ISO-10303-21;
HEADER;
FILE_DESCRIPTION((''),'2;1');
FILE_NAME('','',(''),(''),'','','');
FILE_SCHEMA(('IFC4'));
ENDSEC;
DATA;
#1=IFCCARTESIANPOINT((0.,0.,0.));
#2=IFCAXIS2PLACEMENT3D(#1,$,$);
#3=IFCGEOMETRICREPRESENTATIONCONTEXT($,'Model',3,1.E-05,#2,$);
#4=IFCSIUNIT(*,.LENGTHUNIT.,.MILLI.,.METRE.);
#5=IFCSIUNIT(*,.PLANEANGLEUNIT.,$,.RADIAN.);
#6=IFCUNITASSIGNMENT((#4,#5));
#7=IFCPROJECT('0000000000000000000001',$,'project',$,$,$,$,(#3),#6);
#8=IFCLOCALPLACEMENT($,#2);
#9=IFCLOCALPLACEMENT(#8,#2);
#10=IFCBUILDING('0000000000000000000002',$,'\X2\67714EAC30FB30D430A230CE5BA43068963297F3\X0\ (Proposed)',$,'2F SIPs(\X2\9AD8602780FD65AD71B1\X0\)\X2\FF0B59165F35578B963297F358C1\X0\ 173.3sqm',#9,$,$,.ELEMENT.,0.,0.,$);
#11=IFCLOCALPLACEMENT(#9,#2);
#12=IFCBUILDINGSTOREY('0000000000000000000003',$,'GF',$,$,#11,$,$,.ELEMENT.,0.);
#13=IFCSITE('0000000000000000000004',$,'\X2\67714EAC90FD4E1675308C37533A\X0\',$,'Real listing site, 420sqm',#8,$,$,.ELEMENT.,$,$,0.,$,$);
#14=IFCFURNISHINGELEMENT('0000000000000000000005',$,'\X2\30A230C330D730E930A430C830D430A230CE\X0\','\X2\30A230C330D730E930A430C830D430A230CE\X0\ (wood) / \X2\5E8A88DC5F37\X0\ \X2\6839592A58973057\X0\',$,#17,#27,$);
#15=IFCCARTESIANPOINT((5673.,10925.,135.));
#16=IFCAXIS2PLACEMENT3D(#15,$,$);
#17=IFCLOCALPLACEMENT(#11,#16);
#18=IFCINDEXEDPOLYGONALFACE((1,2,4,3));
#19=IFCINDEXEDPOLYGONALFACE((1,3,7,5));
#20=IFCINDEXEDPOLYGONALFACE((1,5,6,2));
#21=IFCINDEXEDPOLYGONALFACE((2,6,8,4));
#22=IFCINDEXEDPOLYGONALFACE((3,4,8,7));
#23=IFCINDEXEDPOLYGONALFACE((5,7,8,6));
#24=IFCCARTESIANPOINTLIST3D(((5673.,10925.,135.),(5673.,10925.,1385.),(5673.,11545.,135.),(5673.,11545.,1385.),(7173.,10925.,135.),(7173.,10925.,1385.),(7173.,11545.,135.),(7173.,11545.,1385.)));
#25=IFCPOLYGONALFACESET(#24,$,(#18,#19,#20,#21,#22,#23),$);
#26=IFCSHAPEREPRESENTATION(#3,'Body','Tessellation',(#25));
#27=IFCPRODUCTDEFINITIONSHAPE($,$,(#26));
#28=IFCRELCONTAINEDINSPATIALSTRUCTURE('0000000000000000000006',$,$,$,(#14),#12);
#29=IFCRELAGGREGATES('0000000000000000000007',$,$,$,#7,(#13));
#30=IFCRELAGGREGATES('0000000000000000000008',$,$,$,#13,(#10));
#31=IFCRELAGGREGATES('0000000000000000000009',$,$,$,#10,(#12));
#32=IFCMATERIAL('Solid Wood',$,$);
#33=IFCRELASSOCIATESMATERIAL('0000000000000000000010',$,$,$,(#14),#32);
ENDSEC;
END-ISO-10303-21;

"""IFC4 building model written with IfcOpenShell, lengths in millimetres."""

from ifc_helpers import new_model, si_unit, frame, frame_2d, origin, place, context, project, spatial, rectangle, extrude, material, element, save


model = new_model("IFC4")

# Units and contexts
model_context = context("Model", 3, precision=1e-05, world=origin())
ifc_project = project(units=[si_unit("LENGTHUNIT", "METRE", prefix="MILLI"), si_unit("PLANEANGLEUNIT", "RADIAN")], contexts=[model_context])

# Site, building, storey
site_placement = place(None, origin())
site = spatial("IfcSite", under=ifc_project, at=site_placement, Name="東京都世田谷区", ObjectType="Real listing site, 420sqm", CompositionType="ELEMENT", RefElevation=0.0)
building_placement = place(site_placement, origin())
building = spatial("IfcBuilding", under=site, at=building_placement, Name="東京・ピアノ室と防音 (Proposed)", ObjectType="2F SIPs(高性能断熱)＋外張型防音壁 173.3sqm", CompositionType="ELEMENT", ElevationOfRefHeight=0.0, ElevationOfTerrain=0.0)
storey_placement = place(building_placement, origin())
storey = spatial("IfcBuildingStorey", under=building, at=storey_placement, Name="GF", CompositionType="ELEMENT", Elevation=0.0)

# Shared definitions
ifc_material_1 = material(Name="Solid Wood")

# Furnishing element
furnishing_1_placement = place(storey_placement, frame((5673.0, 10925.0, 135.0)))
element("IfcFurnishingElement", 1, at=furnishing_1_placement, inside=storey, material=ifc_material_1, Name="アップライトピアノ", Description="アップライトピアノ (wood) / 床補強 根太増し", context=model_context, shape_type="SweptSolid", body=[
    extrude(rectangle(XDim=1500.0, YDim=620.0, at=frame_2d((750.0, 310.0))), frame((5673.0, 10925.0, 135.0)), (0.0, 0.0, 1.0), 1250.0),
])

save(model, "model.ifc")
